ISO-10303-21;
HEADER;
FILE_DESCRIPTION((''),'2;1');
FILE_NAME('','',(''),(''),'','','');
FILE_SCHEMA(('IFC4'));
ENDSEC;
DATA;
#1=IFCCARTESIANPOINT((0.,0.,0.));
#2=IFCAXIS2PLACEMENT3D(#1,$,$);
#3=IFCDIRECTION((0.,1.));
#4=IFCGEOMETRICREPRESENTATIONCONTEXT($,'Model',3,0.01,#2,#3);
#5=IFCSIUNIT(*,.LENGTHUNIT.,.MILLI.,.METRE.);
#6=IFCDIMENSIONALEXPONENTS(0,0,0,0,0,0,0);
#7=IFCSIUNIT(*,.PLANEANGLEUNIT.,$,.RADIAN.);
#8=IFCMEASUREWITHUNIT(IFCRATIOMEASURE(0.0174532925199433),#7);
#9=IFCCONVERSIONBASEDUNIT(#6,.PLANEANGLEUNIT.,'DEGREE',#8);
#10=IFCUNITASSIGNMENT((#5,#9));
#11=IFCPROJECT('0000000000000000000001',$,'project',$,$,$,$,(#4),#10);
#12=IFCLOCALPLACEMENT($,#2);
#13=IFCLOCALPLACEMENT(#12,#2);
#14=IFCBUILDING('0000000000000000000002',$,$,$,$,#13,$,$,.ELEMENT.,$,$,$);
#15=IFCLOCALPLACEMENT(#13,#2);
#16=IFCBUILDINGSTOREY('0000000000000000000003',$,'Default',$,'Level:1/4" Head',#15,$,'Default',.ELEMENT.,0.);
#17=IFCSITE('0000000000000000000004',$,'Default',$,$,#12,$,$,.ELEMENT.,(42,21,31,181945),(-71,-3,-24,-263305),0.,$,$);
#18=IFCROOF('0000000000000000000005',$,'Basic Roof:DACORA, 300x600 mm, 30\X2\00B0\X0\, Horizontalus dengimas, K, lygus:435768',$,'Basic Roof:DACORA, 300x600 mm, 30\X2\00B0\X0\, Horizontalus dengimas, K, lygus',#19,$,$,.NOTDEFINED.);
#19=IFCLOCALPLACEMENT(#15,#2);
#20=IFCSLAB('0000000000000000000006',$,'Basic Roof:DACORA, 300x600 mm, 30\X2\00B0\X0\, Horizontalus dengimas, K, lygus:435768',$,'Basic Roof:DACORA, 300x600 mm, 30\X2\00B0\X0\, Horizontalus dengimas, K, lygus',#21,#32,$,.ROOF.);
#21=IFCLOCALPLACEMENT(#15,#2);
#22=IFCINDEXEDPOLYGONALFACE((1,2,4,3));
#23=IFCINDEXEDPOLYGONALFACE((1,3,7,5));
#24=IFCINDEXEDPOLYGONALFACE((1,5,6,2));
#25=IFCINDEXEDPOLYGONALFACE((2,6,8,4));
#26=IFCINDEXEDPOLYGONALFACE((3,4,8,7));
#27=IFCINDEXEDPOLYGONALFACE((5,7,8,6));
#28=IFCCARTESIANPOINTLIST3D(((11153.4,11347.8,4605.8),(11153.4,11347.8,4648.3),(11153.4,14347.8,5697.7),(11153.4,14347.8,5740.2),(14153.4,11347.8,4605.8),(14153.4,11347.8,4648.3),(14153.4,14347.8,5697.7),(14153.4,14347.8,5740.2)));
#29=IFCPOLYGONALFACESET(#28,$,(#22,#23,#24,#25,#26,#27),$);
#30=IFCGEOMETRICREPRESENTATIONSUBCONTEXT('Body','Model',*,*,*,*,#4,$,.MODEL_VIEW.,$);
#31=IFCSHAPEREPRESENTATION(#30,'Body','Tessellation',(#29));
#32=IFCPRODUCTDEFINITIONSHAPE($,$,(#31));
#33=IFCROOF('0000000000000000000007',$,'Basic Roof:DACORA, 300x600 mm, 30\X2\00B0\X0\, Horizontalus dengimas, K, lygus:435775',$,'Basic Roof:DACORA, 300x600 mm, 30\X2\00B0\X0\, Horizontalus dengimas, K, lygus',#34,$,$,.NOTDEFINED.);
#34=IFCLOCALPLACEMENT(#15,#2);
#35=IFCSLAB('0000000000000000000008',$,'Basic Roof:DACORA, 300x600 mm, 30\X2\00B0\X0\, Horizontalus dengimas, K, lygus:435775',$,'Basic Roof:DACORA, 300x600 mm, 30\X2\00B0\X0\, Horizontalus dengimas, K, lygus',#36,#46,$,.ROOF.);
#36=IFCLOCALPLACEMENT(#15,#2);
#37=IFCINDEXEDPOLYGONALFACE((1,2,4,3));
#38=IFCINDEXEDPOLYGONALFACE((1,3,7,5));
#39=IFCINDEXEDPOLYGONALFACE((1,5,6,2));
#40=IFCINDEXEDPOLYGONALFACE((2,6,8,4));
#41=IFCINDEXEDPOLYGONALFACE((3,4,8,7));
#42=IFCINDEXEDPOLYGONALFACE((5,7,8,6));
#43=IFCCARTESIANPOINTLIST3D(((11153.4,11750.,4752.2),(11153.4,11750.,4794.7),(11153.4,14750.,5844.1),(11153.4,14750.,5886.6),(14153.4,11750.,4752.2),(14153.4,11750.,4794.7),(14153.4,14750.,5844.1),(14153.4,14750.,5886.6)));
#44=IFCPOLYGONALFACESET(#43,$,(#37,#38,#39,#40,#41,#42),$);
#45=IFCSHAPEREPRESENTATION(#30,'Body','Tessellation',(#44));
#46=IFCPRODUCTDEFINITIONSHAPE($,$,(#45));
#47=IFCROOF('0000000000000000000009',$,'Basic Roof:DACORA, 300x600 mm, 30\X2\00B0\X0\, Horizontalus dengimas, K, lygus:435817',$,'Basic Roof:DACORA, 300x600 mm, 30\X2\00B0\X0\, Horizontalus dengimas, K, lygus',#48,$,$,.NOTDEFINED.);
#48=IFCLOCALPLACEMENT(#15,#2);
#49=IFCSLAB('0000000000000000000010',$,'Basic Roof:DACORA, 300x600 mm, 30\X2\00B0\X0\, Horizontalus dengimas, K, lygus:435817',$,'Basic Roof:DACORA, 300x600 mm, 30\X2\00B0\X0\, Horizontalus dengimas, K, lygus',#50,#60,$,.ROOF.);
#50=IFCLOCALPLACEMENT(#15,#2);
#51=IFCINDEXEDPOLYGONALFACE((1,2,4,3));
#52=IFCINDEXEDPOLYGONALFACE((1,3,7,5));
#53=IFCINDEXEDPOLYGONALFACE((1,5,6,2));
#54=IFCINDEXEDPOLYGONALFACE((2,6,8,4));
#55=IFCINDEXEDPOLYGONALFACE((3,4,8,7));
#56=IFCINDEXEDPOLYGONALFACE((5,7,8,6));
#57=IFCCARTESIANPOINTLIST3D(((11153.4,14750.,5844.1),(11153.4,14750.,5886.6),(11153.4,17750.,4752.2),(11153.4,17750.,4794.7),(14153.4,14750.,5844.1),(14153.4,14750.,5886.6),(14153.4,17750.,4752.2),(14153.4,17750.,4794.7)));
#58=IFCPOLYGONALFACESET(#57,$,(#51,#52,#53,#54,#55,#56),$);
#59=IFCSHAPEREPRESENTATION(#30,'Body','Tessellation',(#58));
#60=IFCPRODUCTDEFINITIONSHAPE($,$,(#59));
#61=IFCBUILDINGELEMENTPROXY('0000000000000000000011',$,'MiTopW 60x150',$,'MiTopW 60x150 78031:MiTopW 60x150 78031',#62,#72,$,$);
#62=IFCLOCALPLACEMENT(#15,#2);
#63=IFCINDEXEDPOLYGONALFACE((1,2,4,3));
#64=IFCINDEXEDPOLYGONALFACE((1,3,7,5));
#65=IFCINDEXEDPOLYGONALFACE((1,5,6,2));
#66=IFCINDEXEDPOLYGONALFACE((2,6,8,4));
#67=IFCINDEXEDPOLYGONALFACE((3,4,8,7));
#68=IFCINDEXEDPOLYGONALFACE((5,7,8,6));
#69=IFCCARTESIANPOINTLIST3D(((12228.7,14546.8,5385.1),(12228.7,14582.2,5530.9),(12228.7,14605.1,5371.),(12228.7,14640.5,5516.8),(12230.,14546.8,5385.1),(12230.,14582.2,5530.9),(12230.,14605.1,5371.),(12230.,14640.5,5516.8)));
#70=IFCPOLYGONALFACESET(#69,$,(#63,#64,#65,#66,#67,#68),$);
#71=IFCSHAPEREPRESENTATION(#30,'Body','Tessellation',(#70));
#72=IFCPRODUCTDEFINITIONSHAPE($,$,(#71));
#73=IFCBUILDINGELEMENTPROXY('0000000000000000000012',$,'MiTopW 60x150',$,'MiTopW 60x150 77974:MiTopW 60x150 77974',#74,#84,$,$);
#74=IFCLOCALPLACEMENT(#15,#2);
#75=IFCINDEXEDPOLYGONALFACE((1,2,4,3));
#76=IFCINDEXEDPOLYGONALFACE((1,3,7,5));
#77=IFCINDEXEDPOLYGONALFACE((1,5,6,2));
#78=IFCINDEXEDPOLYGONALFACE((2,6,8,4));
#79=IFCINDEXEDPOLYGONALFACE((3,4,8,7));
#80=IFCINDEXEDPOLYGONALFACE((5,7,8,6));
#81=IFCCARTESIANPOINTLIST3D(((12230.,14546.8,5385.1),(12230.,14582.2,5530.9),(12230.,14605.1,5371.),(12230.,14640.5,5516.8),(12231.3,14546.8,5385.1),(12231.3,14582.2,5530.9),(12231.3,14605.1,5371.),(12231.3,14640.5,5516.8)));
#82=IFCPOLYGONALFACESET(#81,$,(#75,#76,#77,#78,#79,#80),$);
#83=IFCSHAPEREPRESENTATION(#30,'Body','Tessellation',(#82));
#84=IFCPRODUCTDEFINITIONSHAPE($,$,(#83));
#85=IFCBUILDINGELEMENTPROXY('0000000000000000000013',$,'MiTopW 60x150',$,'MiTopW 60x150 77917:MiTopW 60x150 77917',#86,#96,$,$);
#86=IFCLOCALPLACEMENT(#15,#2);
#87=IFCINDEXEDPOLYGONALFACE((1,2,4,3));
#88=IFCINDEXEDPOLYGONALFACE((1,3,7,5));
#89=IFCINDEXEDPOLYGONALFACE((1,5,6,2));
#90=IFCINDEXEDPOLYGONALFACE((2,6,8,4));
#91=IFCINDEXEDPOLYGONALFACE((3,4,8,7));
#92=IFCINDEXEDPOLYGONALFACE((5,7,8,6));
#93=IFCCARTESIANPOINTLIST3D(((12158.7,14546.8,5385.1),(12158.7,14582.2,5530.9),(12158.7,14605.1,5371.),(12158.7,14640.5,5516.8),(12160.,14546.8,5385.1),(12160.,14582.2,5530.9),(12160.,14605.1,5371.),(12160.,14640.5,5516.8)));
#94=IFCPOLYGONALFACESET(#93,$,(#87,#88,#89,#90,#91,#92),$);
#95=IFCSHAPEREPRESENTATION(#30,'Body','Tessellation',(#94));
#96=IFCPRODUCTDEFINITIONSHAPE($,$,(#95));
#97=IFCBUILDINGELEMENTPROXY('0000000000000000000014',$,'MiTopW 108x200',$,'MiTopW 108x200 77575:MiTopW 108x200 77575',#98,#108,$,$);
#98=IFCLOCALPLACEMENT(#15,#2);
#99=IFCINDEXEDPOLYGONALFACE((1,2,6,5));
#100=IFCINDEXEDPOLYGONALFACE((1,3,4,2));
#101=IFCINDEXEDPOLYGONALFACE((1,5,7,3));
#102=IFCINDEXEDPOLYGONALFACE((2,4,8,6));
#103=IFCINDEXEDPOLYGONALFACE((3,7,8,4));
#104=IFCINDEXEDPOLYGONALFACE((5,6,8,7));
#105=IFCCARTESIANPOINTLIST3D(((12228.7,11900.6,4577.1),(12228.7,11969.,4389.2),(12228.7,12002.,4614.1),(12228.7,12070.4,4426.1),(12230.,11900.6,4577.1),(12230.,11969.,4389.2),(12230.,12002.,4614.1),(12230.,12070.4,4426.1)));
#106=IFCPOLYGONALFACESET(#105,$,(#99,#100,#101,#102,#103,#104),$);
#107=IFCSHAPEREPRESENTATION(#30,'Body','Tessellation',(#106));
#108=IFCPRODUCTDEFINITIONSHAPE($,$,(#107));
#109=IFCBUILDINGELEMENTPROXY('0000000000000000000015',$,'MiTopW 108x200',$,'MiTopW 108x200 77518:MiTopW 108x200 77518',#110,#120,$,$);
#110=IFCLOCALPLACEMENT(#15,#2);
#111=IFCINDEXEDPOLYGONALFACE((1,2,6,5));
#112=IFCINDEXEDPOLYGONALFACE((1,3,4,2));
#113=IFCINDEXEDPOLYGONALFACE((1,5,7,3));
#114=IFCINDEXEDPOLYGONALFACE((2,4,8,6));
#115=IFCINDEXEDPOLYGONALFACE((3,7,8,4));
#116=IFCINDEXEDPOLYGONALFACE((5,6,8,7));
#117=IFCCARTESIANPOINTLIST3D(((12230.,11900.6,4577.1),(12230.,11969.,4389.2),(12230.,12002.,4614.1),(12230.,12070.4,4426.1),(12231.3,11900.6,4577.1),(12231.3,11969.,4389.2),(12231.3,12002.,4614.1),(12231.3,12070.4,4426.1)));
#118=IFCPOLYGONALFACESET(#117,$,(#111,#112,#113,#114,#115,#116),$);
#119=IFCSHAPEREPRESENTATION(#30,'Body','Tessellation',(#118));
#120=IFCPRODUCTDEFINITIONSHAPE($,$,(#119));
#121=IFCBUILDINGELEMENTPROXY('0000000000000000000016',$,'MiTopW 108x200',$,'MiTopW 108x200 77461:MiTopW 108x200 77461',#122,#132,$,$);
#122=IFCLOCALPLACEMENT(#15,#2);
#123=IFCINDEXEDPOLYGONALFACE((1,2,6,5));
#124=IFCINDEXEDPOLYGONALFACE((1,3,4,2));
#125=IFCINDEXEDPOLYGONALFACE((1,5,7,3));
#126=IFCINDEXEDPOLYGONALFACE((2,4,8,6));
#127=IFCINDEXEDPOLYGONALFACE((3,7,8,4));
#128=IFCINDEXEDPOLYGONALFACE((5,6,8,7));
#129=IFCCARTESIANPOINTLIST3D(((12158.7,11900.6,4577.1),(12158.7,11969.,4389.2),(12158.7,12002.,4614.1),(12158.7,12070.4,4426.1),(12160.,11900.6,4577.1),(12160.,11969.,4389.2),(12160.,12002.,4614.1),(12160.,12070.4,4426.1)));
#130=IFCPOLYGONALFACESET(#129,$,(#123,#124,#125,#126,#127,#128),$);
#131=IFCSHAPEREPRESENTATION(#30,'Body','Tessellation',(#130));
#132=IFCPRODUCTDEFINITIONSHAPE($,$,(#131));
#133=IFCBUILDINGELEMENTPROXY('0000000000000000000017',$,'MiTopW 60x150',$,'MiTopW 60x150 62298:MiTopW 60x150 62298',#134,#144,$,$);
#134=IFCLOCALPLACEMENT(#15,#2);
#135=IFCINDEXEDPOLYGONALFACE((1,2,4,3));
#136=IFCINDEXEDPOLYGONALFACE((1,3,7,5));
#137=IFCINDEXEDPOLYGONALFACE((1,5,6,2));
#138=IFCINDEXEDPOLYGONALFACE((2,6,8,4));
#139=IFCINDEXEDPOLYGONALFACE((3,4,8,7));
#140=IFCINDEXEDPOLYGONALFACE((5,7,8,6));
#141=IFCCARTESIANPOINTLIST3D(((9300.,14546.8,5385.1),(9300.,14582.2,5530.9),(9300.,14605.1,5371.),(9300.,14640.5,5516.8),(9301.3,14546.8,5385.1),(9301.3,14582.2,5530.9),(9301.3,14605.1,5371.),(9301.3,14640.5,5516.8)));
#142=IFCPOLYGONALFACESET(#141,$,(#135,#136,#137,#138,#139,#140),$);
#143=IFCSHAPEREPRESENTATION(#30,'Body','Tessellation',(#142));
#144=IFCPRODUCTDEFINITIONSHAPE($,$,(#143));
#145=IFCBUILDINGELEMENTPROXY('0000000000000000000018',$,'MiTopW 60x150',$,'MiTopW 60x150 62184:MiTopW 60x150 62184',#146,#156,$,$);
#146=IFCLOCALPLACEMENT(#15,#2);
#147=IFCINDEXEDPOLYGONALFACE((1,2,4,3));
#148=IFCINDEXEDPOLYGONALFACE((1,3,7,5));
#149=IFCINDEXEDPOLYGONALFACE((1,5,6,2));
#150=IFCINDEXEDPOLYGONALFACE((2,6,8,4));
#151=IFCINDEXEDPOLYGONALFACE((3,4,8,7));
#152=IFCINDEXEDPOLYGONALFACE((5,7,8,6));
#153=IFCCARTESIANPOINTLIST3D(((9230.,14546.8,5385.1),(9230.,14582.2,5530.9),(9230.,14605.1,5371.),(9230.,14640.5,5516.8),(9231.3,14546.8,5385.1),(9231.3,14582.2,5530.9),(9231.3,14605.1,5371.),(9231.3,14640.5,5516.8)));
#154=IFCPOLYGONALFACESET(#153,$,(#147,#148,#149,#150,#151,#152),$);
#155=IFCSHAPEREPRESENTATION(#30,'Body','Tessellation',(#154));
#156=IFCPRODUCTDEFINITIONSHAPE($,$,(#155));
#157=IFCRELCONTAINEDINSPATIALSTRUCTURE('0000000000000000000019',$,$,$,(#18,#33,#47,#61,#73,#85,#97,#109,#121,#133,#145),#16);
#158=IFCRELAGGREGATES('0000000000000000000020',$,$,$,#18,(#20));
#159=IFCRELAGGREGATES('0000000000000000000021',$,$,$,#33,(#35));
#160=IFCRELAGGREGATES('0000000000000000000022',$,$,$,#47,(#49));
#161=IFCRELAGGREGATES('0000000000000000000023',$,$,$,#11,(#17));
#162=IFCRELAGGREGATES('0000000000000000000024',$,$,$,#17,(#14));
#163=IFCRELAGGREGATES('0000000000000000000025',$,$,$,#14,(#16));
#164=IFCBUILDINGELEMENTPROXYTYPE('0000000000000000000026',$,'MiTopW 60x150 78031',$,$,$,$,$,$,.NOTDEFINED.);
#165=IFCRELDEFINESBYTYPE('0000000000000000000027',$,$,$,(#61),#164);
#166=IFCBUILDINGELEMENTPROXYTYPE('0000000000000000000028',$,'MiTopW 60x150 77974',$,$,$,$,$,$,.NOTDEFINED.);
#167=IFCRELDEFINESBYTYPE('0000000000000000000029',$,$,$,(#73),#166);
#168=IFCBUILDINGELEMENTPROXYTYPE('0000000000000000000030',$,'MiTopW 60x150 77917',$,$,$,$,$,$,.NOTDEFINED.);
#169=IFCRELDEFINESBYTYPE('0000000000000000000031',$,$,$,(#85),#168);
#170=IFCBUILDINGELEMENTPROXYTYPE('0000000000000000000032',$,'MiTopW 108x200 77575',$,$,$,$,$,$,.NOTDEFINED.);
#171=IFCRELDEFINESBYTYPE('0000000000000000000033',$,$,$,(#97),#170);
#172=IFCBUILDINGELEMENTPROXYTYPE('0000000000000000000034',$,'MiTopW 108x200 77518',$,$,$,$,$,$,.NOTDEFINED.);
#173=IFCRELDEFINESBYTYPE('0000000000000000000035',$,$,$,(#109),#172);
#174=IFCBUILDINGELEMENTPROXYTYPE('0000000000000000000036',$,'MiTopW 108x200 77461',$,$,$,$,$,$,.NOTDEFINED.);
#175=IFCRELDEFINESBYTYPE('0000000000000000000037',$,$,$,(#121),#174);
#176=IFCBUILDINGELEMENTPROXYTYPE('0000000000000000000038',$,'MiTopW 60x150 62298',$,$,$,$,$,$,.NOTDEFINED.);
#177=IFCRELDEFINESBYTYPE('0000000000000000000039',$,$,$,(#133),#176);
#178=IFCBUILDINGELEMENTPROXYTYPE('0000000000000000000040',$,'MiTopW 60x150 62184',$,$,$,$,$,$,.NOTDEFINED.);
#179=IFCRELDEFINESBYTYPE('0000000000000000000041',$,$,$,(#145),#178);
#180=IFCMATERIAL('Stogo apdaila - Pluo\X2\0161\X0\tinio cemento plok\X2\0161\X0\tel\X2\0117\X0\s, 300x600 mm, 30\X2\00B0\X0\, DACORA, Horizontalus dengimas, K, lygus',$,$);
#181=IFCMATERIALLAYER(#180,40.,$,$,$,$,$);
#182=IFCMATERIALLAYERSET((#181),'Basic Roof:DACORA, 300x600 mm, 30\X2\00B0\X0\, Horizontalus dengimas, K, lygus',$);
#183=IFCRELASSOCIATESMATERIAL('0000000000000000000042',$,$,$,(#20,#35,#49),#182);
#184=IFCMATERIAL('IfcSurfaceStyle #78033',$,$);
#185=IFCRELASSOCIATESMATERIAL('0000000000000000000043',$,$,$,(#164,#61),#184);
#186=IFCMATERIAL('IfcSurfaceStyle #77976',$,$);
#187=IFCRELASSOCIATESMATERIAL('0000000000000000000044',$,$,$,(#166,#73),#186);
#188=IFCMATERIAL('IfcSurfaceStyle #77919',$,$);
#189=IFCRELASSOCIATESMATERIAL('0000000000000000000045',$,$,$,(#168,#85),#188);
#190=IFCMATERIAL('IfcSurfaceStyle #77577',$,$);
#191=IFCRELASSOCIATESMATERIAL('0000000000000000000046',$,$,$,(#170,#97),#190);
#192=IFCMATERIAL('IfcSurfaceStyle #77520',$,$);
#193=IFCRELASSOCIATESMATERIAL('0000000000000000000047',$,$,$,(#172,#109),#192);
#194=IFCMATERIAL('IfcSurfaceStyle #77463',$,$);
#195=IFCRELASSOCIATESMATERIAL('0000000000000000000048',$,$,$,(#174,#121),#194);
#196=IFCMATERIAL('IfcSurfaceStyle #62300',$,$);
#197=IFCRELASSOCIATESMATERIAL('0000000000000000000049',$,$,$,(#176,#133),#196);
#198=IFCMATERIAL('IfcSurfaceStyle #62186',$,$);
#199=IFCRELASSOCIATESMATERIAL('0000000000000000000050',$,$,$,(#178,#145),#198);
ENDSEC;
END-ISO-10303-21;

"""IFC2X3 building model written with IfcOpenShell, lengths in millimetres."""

from ifc_helpers import new_model, entity, si_unit, converted_unit, direction, frame, frame_2d, origin, place, context, subcontext, project, spatial, polyline, rectangle, outline, extrude, source, transform, mapped, material, layer, layer_set, type_object, type_shapes, element, aggregate, save


model = new_model("IFC2X3")

# Units and contexts
model_context = context("Model", 3, precision=0.01, world=origin(), true_north=direction((0.0, 1.0)))
body_context = subcontext(model_context, "Body", "Model", "MODEL_VIEW")
ifc_project = project(units=[si_unit("LENGTHUNIT", "METRE", prefix="MILLI"), converted_unit("PLANEANGLEUNIT", "DEGREE", entity("IfcRatioMeasure", 0.0174532925199433), si_unit("PLANEANGLEUNIT", "RADIAN"), dimensions=[0, 0, 0, 0, 0, 0, 0])], contexts=[model_context])

# Site, building, storey
site_placement = place(None, origin())
site = spatial("IfcSite", under=ifc_project, at=site_placement, Name="Default", CompositionType="ELEMENT", RefLatitude=(42, 21, 31, 181945), RefLongitude=(-71, -3, -24, -263305), RefElevation=0.0)
building_placement = place(site_placement, origin())
building = spatial("IfcBuilding", under=site, at=building_placement, CompositionType="ELEMENT")
storey_placement = place(building_placement, origin())
storey = spatial("IfcBuildingStorey", under=building, at=storey_placement, Name="Default", ObjectType="Level:1/4\" Head", LongName="Default", CompositionType="ELEMENT", Elevation=0.0)

# Roofs, slabs
roof_1_placement = place(storey_placement, frame((11153.4, 11347.8, 4605.8)))
roof_1 = element("IfcRoof", 1, at=roof_1_placement, inside=storey, Name="Basic Roof:DACORA, 300x600 mm, 30°, Horizontalus dengimas, K, lygus:435768", ObjectType="Basic Roof:DACORA, 300x600 mm, 30°, Horizontalus dengimas, K, lygus", ShapeType="NOTDEFINED")
ifc_material_1 = material(Name="Stogo apdaila - Pluoštinio cemento plokštelės, 300x600 mm, 30°, DACORA, Horizontalus dengimas, K, lygus")
ifc_layer = layer(ifc_material_1, 40.0)
ifc_layer_set = layer_set([ifc_layer], Name="Basic Roof:DACORA, 300x600 mm, 30°, Horizontalus dengimas, K, lygus")
slab_1_placement = place(roof_1_placement, origin())
slab_1 = element("IfcSlab", 2, at=slab_1_placement, material=ifc_layer_set, Name="Basic Roof:DACORA, 300x600 mm, 30°, Horizontalus dengimas, K, lygus:435768", ObjectType="Basic Roof:DACORA, 300x600 mm, 30°, Horizontalus dengimas, K, lygus", PredefinedType="ROOF", context=body_context, shape_type="SweptSolid", body=[
    extrude(rectangle(XDim=3192.5, YDim=3000.0, at=frame_2d((0.0, 0.0), x_axis=(0.0, -1.0))), frame((1500.0, 1500.0, 546.0), z_axis=(0.0, -0.34202, 0.939693), x_axis=(1.0, 0.0, 0.0)), (0.0, 0.34202, 0.939693), 42.6),
])
aggregate(roof_1, [slab_1])
roof_2_placement = place(storey_placement, frame((11153.4, 11750.0, 4752.2)))
roof_2 = element("IfcRoof", 3, at=roof_2_placement, inside=storey, Name="Basic Roof:DACORA, 300x600 mm, 30°, Horizontalus dengimas, K, lygus:435775", ObjectType="Basic Roof:DACORA, 300x600 mm, 30°, Horizontalus dengimas, K, lygus", ShapeType="NOTDEFINED")
slab_2_placement = place(roof_2_placement, origin())
slab_2 = element("IfcSlab", 4, at=slab_2_placement, material=ifc_layer_set, Name="Basic Roof:DACORA, 300x600 mm, 30°, Horizontalus dengimas, K, lygus:435775", ObjectType="Basic Roof:DACORA, 300x600 mm, 30°, Horizontalus dengimas, K, lygus", PredefinedType="ROOF", context=body_context, shape_type="SweptSolid", body=[
    extrude(rectangle(XDim=3192.5, YDim=3000.0, at=frame_2d((0.0, 0.0), x_axis=(0.0, -1.0))), frame((1500.0, 1500.0, 546.0), z_axis=(0.0, -0.34202, 0.939693), x_axis=(1.0, 0.0, 0.0)), (0.0, 0.34202, 0.939693), 42.6),
])
aggregate(roof_2, [slab_2])
roof_3_placement = place(storey_placement, frame((11153.4, 14750.0, 4752.2)))
roof_3 = element("IfcRoof", 5, at=roof_3_placement, inside=storey, Name="Basic Roof:DACORA, 300x600 mm, 30°, Horizontalus dengimas, K, lygus:435817", ObjectType="Basic Roof:DACORA, 300x600 mm, 30°, Horizontalus dengimas, K, lygus", ShapeType="NOTDEFINED")
slab_3_placement = place(roof_3_placement, origin())
slab_3 = element("IfcSlab", 6, at=slab_3_placement, material=ifc_layer_set, Name="Basic Roof:DACORA, 300x600 mm, 30°, Horizontalus dengimas, K, lygus:435817", ObjectType="Basic Roof:DACORA, 300x600 mm, 30°, Horizontalus dengimas, K, lygus", PredefinedType="ROOF", context=body_context, shape_type="SweptSolid", body=[
    extrude(rectangle(XDim=3192.5, YDim=3000.0, at=frame_2d((0.0, 0.0), x_axis=(0.0, 1.0))), frame((1500.0, 1500.0, 546.0), z_axis=(0.0, 0.34202, 0.939693), x_axis=(1.0, 0.0, 0.0)), (0.0, -0.34202, 0.939693), 42.6),
])
aggregate(roof_3, [slab_3])

# Building element proxies
ifc_material_2 = material(Name="IfcSurfaceStyle #78033")
building_element_proxy_type_1 = type_object("IfcBuildingElementProxyType", Name="MiTopW 60x150 78031", PredefinedType="NOTDEFINED", material=ifc_material_2)
shared_shape_1 = source(origin(), body_context, "Body", "SweptSolid", [
    extrude(outline(polyline([(-75.0, -30.0), (75.0, -30.0), (75.0, 30.0), (-75.0, 30.0), (-75.0, -30.0)])), frame((75.0, 30.0, 0.0), z_axis=(0.0, 0.0, 1.0), x_axis=(-1.0, 0.0, 0.0)), (0.0, 0.0, 1.0), 1.3),
])
type_shapes(building_element_proxy_type_1, [shared_shape_1])
proxy_1_placement = place(building_placement, frame((12230.0, 14640.5, 5516.8), z_axis=(-1.0, 0.0, 0.0), x_axis=(0.0, -0.235626, -0.971844)))
element("IfcBuildingElementProxy", 7, at=proxy_1_placement, inside=storey, type_object=building_element_proxy_type_1, material=ifc_material_2, Name="MiTopW 60x150", ObjectType="MiTopW 60x150 78031:MiTopW 60x150 78031", context=body_context, shape_type="MappedRepresentation", body=[
    mapped(shared_shape_1, transform((0.0, 0.0, 0.0), scale=1.0)),
])
ifc_material_3 = material(Name="IfcSurfaceStyle #77976")
building_element_proxy_type_2 = type_object("IfcBuildingElementProxyType", Name="MiTopW 60x150 77974", PredefinedType="NOTDEFINED", material=ifc_material_3)
shared_shape_2 = source(origin(), body_context, "Body", "SweptSolid", [
    extrude(outline(polyline([(-75.0, -30.0), (75.0, -30.0), (75.0, 30.0), (-75.0, 30.0), (-75.0, -30.0)])), frame((75.0, 30.0, 0.0), z_axis=(0.0, 0.0, 1.0), x_axis=(-1.0, 0.0, 0.0)), (0.0, 0.0, 1.0), 1.3),
])
type_shapes(building_element_proxy_type_2, [shared_shape_2])
proxy_2_placement = place(building_placement, frame((12231.3, 14640.5, 5516.8), z_axis=(-1.0, 0.0, 0.0), x_axis=(0.0, -0.235626, -0.971844)))
element("IfcBuildingElementProxy", 8, at=proxy_2_placement, inside=storey, type_object=building_element_proxy_type_2, material=ifc_material_3, Name="MiTopW 60x150", ObjectType="MiTopW 60x150 77974:MiTopW 60x150 77974", context=body_context, shape_type="MappedRepresentation", body=[
    mapped(shared_shape_2, transform((0.0, 0.0, 0.0), scale=1.0)),
])
ifc_material_4 = material(Name="IfcSurfaceStyle #77919")
building_element_proxy_type_3 = type_object("IfcBuildingElementProxyType", Name="MiTopW 60x150 77917", PredefinedType="NOTDEFINED", material=ifc_material_4)
shared_shape_3 = source(origin(), body_context, "Body", "SweptSolid", [
    extrude(outline(polyline([(-75.0, -30.0), (75.0, -30.0), (75.0, 30.0), (-75.0, 30.0), (-75.0, -30.0)])), frame((75.0, 30.0, 0.0), z_axis=(0.0, 0.0, 1.0), x_axis=(-1.0, 0.0, 0.0)), (0.0, 0.0, 1.0), 1.3),
])
type_shapes(building_element_proxy_type_3, [shared_shape_3])
proxy_3_placement = place(building_placement, frame((12160.0, 14640.5, 5516.8), z_axis=(-1.0, 0.0, 0.0), x_axis=(0.0, -0.235626, -0.971844)))
element("IfcBuildingElementProxy", 9, at=proxy_3_placement, inside=storey, type_object=building_element_proxy_type_3, material=ifc_material_4, Name="MiTopW 60x150", ObjectType="MiTopW 60x150 77917:MiTopW 60x150 77917", context=body_context, shape_type="MappedRepresentation", body=[
    mapped(shared_shape_3, transform((0.0, 0.0, 0.0), scale=1.0)),
])
ifc_material_5 = material(Name="IfcSurfaceStyle #77577")
building_element_proxy_type_4 = type_object("IfcBuildingElementProxyType", Name="MiTopW 108x200 77575", PredefinedType="NOTDEFINED", material=ifc_material_5)
shared_shape_4 = source(origin(), body_context, "Body", "SweptSolid", [
    extrude(outline(polyline([(-54.0, -100.0), (54.0, -100.0), (54.0, 100.0), (-54.0, 100.0), (-54.0, -100.0)])), frame((100.0, 54.0, 0.0), z_axis=(0.0, 0.0, 1.0), x_axis=(-0.000002, 1.0, 0.0)), (0.0, 0.0, 1.0), 1.3),
])
type_shapes(building_element_proxy_type_4, [shared_shape_4])
proxy_4_placement = place(building_placement, frame((12230.0, 12002.0, 4614.1), z_axis=(-1.0, 0.0, 0.0), x_axis=(0.0, 0.34202, -0.939693)))
element("IfcBuildingElementProxy", 10, at=proxy_4_placement, inside=storey, type_object=building_element_proxy_type_4, material=ifc_material_5, Name="MiTopW 108x200", ObjectType="MiTopW 108x200 77575:MiTopW 108x200 77575", context=body_context, shape_type="MappedRepresentation", body=[
    mapped(shared_shape_4, transform((0.0, 0.0, 0.0), scale=1.0)),
])
ifc_material_6 = material(Name="IfcSurfaceStyle #77520")
building_element_proxy_type_5 = type_object("IfcBuildingElementProxyType", Name="MiTopW 108x200 77518", PredefinedType="NOTDEFINED", material=ifc_material_6)
shared_shape_5 = source(origin(), body_context, "Body", "SweptSolid", [
    extrude(outline(polyline([(-54.0, -100.0), (54.0, -100.0), (54.0, 100.0), (-54.0, 100.0), (-54.0, -100.0)])), frame((100.0, 54.0, 0.0), z_axis=(0.0, 0.0, 1.0), x_axis=(-0.000002, 1.0, 0.0)), (0.0, 0.0, 1.0), 1.3),
])
type_shapes(building_element_proxy_type_5, [shared_shape_5])
proxy_5_placement = place(building_placement, frame((12231.3, 12002.0, 4614.1), z_axis=(-1.0, 0.0, 0.0), x_axis=(0.0, 0.34202, -0.939693)))
element("IfcBuildingElementProxy", 11, at=proxy_5_placement, inside=storey, type_object=building_element_proxy_type_5, material=ifc_material_6, Name="MiTopW 108x200", ObjectType="MiTopW 108x200 77518:MiTopW 108x200 77518", context=body_context, shape_type="MappedRepresentation", body=[
    mapped(shared_shape_5, transform((0.0, 0.0, 0.0), scale=1.0)),
])
ifc_material_7 = material(Name="IfcSurfaceStyle #77463")
building_element_proxy_type_6 = type_object("IfcBuildingElementProxyType", Name="MiTopW 108x200 77461", PredefinedType="NOTDEFINED", material=ifc_material_7)
shared_shape_6 = source(origin(), body_context, "Body", "SweptSolid", [
    extrude(outline(polyline([(-54.0, -100.0), (54.0, -100.0), (54.0, 100.0), (-54.0, 100.0), (-54.0, -100.0)])), frame((100.0, 54.0, 0.0), z_axis=(0.0, 0.0, 1.0), x_axis=(-0.000002, 1.0, 0.0)), (0.0, 0.0, 1.0), 1.3),
])
type_shapes(building_element_proxy_type_6, [shared_shape_6])
proxy_6_placement = place(building_placement, frame((12160.0, 12002.0, 4614.1), z_axis=(-1.0, 0.0, 0.0), x_axis=(0.0, 0.34202, -0.939693)))
element("IfcBuildingElementProxy", 12, at=proxy_6_placement, inside=storey, type_object=building_element_proxy_type_6, material=ifc_material_7, Name="MiTopW 108x200", ObjectType="MiTopW 108x200 77461:MiTopW 108x200 77461", context=body_context, shape_type="MappedRepresentation", body=[
    mapped(shared_shape_6, transform((0.0, 0.0, 0.0), scale=1.0)),
])
ifc_material_8 = material(Name="IfcSurfaceStyle #62300")
building_element_proxy_type_7 = type_object("IfcBuildingElementProxyType", Name="MiTopW 60x150 62298", PredefinedType="NOTDEFINED", material=ifc_material_8)
shared_shape_7 = source(origin(), body_context, "Body", "SweptSolid", [
    extrude(outline(polyline([(-75.0, -30.0), (75.0, -30.0), (75.0, 30.0), (-75.0, 30.0), (-75.0, -30.0)])), frame((75.0, 30.0, 0.0), z_axis=(0.0, 0.0, 1.0), x_axis=(-1.0, 0.0, 0.0)), (0.0, 0.0, 1.0), 1.3),
])
type_shapes(building_element_proxy_type_7, [shared_shape_7])
proxy_7_placement = place(building_placement, frame((9301.3, 14640.5, 5516.8), z_axis=(-1.0, 0.0, 0.0), x_axis=(0.0, -0.235626, -0.971844)))
element("IfcBuildingElementProxy", 13, at=proxy_7_placement, inside=storey, type_object=building_element_proxy_type_7, material=ifc_material_8, Name="MiTopW 60x150", ObjectType="MiTopW 60x150 62298:MiTopW 60x150 62298", context=body_context, shape_type="MappedRepresentation", body=[
    mapped(shared_shape_7, transform((0.0, 0.0, 0.0), scale=1.0)),
])
ifc_material_9 = material(Name="IfcSurfaceStyle #62186")
building_element_proxy_type_8 = type_object("IfcBuildingElementProxyType", Name="MiTopW 60x150 62184", PredefinedType="NOTDEFINED", material=ifc_material_9)
shared_shape_8 = source(origin(), body_context, "Body", "SweptSolid", [
    extrude(outline(polyline([(-75.0, -30.0), (75.0, -30.0), (75.0, 30.0), (-75.0, 30.0), (-75.0, -30.0)])), frame((75.0, 30.0, 0.0), z_axis=(0.0, 0.0, 1.0), x_axis=(-1.0, 0.0, 0.0)), (0.0, 0.0, 1.0), 1.3),
])
type_shapes(building_element_proxy_type_8, [shared_shape_8])
proxy_8_placement = place(building_placement, frame((9231.3, 14640.5, 5516.8), z_axis=(-1.0, 0.0, 0.0), x_axis=(0.0, -0.235626, -0.971844)))
element("IfcBuildingElementProxy", 14, at=proxy_8_placement, inside=storey, type_object=building_element_proxy_type_8, material=ifc_material_9, Name="MiTopW 60x150", ObjectType="MiTopW 60x150 62184:MiTopW 60x150 62184", context=body_context, shape_type="MappedRepresentation", body=[
    mapped(shared_shape_8, transform((0.0, 0.0, 0.0), scale=1.0)),
])

save(model, "model.ifc")
